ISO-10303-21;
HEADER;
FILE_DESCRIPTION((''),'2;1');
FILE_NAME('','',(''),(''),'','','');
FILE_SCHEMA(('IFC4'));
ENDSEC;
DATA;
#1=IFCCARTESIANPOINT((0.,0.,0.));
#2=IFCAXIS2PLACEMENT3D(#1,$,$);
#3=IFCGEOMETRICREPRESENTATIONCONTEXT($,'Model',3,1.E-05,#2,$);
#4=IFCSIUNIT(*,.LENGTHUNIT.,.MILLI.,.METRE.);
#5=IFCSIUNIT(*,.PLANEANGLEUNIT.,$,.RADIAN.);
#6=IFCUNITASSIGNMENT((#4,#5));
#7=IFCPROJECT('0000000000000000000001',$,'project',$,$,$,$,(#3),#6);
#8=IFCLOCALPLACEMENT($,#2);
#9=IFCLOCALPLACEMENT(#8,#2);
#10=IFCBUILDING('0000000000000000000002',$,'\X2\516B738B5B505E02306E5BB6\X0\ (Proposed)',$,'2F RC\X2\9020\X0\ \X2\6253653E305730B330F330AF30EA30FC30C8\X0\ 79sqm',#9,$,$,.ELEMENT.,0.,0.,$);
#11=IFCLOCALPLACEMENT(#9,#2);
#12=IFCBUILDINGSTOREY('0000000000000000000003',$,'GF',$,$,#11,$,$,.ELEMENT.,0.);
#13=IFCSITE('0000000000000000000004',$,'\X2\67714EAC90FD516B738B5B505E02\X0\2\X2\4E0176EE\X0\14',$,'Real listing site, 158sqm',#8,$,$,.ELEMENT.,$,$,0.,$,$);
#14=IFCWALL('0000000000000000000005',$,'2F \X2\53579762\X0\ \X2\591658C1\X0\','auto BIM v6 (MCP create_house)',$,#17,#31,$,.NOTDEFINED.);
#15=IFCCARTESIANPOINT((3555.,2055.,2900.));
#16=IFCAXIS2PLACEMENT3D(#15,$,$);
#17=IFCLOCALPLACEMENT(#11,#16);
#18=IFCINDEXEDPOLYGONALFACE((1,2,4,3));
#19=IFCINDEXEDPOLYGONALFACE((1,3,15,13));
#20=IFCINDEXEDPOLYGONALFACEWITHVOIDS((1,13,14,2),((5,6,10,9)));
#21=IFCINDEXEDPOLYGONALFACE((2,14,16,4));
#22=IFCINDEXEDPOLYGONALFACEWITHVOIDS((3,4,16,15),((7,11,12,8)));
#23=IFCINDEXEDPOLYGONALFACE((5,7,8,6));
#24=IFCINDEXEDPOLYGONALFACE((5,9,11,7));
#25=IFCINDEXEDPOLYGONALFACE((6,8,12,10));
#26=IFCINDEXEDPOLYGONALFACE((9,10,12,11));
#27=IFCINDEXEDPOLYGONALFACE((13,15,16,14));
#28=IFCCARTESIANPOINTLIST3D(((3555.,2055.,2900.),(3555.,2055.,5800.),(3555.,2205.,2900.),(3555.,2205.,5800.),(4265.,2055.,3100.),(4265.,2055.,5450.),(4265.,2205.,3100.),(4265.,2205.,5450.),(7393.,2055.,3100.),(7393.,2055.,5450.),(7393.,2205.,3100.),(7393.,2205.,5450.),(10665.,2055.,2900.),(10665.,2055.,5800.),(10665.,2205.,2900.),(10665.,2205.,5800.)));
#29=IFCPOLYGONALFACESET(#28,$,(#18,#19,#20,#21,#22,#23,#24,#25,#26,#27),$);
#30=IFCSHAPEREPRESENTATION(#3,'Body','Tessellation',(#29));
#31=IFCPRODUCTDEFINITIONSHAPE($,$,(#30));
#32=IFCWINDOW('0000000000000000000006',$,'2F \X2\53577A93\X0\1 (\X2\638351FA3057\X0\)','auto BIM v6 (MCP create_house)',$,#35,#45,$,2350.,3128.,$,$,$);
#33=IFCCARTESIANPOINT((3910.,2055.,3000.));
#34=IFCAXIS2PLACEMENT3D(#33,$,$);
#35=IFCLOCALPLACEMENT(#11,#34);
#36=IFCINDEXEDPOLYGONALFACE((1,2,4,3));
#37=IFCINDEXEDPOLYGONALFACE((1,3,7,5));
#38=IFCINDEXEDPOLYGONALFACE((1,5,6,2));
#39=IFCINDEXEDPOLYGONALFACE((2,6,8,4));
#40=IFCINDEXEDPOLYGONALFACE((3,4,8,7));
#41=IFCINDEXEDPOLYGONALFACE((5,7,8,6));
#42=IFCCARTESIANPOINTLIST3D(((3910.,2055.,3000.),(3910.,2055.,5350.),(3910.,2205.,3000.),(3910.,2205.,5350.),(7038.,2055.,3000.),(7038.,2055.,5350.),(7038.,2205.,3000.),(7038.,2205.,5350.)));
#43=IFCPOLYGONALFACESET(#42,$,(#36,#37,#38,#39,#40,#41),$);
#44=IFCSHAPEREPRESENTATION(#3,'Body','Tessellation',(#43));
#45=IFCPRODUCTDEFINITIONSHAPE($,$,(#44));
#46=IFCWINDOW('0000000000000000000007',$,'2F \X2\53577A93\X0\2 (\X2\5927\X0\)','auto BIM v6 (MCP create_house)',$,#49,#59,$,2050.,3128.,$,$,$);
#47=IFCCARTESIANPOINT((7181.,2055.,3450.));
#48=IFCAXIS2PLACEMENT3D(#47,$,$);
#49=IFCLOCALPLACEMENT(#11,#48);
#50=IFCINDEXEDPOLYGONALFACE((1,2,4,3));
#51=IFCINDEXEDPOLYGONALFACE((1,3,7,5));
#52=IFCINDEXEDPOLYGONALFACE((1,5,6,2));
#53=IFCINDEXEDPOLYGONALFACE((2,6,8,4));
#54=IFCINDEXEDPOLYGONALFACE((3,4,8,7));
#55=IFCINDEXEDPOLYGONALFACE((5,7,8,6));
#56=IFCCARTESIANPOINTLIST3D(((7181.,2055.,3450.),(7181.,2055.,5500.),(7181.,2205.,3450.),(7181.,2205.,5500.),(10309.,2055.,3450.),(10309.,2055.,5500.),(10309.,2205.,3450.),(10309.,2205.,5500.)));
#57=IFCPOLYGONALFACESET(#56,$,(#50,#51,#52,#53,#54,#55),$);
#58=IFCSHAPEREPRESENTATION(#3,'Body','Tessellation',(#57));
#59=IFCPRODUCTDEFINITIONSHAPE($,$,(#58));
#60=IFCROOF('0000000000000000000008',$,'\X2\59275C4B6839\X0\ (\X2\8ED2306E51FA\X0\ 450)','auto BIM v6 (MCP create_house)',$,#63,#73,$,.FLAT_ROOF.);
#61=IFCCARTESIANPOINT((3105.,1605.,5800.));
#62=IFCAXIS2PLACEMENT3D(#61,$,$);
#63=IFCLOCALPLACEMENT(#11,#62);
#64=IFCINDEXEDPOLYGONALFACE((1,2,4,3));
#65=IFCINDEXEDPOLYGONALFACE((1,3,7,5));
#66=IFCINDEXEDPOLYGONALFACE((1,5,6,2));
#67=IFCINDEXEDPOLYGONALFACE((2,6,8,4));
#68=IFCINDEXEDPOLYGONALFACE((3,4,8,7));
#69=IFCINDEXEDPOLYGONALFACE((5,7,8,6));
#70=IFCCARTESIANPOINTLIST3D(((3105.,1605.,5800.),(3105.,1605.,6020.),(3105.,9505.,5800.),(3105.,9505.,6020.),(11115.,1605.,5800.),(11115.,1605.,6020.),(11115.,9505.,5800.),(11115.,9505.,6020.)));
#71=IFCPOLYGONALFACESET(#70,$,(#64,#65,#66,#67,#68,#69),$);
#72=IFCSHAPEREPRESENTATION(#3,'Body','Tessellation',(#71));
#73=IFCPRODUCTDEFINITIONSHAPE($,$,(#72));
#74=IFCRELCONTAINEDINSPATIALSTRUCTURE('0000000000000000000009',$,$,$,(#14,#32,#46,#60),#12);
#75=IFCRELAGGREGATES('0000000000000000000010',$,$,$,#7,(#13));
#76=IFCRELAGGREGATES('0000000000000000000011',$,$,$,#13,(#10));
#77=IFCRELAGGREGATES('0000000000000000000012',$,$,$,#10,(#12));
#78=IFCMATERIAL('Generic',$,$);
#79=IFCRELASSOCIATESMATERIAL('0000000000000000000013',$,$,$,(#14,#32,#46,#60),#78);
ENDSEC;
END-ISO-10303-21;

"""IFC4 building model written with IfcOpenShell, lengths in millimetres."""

from ifc_helpers import new_model, si_unit, frame, frame_2d, origin, place, context, project, spatial, rectangle, extrude, material, element, fill, save


model = new_model("IFC4")

# Units and contexts
model_context = context("Model", 3, precision=1e-05, world=origin())
ifc_project = project(units=[si_unit("LENGTHUNIT", "METRE", prefix="MILLI"), si_unit("PLANEANGLEUNIT", "RADIAN")], contexts=[model_context])

# Site, building, storey
site_placement = place(None, origin())
site = spatial("IfcSite", under=ifc_project, at=site_placement, Name="東京都八王子市2丁目14", ObjectType="Real listing site, 158sqm", CompositionType="ELEMENT", RefElevation=0.0)
building_placement = place(site_placement, origin())
building = spatial("IfcBuilding", under=site, at=building_placement, Name="八王子市の家 (Proposed)", ObjectType="2F RC造 打放しコンクリート 79sqm", CompositionType="ELEMENT", ElevationOfRefHeight=0.0, ElevationOfTerrain=0.0)
storey_placement = place(building_placement, origin())
storey = spatial("IfcBuildingStorey", under=building, at=storey_placement, Name="GF", CompositionType="ELEMENT", Elevation=0.0)

# Shared definitions
ifc_material = material(Name="Generic")

# Wall, openings, windows
wall_1_placement = place(storey_placement, frame((3555.0, 2055.0, 2900.0)))
wall_1 = element("IfcWall", 1, at=wall_1_placement, inside=storey, material=ifc_material, Name="2F 南面 外壁", Description="auto BIM v6 (MCP create_house)", PredefinedType="NOTDEFINED", context=model_context, shape_type="SweptSolid", body=[
    extrude(rectangle(XDim=7110.0, YDim=150.0, at=frame_2d((3555.0, 75.0))), frame((3555.0, 2055.0, 2900.0)), (0.0, 0.0, 1.0), 2900.0),
])
opening_1_placement = place(storey_placement, frame((3910.0, 2055.0, 3000.0)))
opening_1 = element("IfcOpeningElement", 2, at=opening_1_placement, cuts=wall_1, PredefinedType="NOTDEFINED", context=model_context, shape_type="SweptSolid", body=[
    extrude(rectangle(XDim=3128.0, YDim=150.0, at=frame_2d((1564.0, 75.0))), frame((3910.0, 2055.0, 3000.0)), (0.0, 0.0, 1.0), 2350.0),
])
opening_2_placement = place(storey_placement, frame((7181.0, 2055.0, 3450.0)))
opening_2 = element("IfcOpeningElement", 3, at=opening_2_placement, cuts=wall_1, PredefinedType="NOTDEFINED", context=model_context, shape_type="SweptSolid", body=[
    extrude(rectangle(XDim=3128.0, YDim=150.0, at=frame_2d((1564.0, 75.0))), frame((7181.0, 2055.0, 3450.0)), (0.0, 0.0, 1.0), 2050.0),
])
window_1_placement = place(storey_placement, frame((3910.0, 2055.0, 3000.0)))
window_1 = element("IfcWindow", 4, at=window_1_placement, inside=storey, material=ifc_material, Name="2F 南窓1 (掃出し)", Description="auto BIM v6 (MCP create_house)", OverallHeight=2350.0, OverallWidth=3128.0, context=model_context, shape_type="SweptSolid", body=[
    extrude(rectangle(XDim=3128.0, YDim=150.0, at=frame_2d((1564.0, 75.0))), frame((3910.0, 2055.0, 3000.0)), (0.0, 0.0, 1.0), 2350.0),
])
fill(opening_1, window_1)
window_2_placement = place(storey_placement, frame((7181.0, 2055.0, 3450.0)))
window_2 = element("IfcWindow", 5, at=window_2_placement, inside=storey, material=ifc_material, Name="2F 南窓2 (大)", Description="auto BIM v6 (MCP create_house)", OverallHeight=2050.0, OverallWidth=3128.0, context=model_context, shape_type="SweptSolid", body=[
    extrude(rectangle(XDim=3128.0, YDim=150.0, at=frame_2d((1564.0, 75.0))), frame((7181.0, 2055.0, 3450.0)), (0.0, 0.0, 1.0), 2050.0),
])
fill(opening_2, window_2)

# Roof
roof_placement = place(storey_placement, frame((3105.0, 1605.0, 5800.0)))
element("IfcRoof", 6, at=roof_placement, inside=storey, material=ifc_material, Name="大屋根 (軒の出 450)", Description="auto BIM v6 (MCP create_house)", PredefinedType="FLAT_ROOF", context=model_context, shape_type="SweptSolid", body=[
    extrude(rectangle(XDim=8010.0, YDim=7900.0, at=frame_2d((4005.0, 3950.0))), frame((3105.0, 1605.0, 5800.0)), (0.0, 0.0, 1.0), 220.0),
])

save(model, "model.ifc")
